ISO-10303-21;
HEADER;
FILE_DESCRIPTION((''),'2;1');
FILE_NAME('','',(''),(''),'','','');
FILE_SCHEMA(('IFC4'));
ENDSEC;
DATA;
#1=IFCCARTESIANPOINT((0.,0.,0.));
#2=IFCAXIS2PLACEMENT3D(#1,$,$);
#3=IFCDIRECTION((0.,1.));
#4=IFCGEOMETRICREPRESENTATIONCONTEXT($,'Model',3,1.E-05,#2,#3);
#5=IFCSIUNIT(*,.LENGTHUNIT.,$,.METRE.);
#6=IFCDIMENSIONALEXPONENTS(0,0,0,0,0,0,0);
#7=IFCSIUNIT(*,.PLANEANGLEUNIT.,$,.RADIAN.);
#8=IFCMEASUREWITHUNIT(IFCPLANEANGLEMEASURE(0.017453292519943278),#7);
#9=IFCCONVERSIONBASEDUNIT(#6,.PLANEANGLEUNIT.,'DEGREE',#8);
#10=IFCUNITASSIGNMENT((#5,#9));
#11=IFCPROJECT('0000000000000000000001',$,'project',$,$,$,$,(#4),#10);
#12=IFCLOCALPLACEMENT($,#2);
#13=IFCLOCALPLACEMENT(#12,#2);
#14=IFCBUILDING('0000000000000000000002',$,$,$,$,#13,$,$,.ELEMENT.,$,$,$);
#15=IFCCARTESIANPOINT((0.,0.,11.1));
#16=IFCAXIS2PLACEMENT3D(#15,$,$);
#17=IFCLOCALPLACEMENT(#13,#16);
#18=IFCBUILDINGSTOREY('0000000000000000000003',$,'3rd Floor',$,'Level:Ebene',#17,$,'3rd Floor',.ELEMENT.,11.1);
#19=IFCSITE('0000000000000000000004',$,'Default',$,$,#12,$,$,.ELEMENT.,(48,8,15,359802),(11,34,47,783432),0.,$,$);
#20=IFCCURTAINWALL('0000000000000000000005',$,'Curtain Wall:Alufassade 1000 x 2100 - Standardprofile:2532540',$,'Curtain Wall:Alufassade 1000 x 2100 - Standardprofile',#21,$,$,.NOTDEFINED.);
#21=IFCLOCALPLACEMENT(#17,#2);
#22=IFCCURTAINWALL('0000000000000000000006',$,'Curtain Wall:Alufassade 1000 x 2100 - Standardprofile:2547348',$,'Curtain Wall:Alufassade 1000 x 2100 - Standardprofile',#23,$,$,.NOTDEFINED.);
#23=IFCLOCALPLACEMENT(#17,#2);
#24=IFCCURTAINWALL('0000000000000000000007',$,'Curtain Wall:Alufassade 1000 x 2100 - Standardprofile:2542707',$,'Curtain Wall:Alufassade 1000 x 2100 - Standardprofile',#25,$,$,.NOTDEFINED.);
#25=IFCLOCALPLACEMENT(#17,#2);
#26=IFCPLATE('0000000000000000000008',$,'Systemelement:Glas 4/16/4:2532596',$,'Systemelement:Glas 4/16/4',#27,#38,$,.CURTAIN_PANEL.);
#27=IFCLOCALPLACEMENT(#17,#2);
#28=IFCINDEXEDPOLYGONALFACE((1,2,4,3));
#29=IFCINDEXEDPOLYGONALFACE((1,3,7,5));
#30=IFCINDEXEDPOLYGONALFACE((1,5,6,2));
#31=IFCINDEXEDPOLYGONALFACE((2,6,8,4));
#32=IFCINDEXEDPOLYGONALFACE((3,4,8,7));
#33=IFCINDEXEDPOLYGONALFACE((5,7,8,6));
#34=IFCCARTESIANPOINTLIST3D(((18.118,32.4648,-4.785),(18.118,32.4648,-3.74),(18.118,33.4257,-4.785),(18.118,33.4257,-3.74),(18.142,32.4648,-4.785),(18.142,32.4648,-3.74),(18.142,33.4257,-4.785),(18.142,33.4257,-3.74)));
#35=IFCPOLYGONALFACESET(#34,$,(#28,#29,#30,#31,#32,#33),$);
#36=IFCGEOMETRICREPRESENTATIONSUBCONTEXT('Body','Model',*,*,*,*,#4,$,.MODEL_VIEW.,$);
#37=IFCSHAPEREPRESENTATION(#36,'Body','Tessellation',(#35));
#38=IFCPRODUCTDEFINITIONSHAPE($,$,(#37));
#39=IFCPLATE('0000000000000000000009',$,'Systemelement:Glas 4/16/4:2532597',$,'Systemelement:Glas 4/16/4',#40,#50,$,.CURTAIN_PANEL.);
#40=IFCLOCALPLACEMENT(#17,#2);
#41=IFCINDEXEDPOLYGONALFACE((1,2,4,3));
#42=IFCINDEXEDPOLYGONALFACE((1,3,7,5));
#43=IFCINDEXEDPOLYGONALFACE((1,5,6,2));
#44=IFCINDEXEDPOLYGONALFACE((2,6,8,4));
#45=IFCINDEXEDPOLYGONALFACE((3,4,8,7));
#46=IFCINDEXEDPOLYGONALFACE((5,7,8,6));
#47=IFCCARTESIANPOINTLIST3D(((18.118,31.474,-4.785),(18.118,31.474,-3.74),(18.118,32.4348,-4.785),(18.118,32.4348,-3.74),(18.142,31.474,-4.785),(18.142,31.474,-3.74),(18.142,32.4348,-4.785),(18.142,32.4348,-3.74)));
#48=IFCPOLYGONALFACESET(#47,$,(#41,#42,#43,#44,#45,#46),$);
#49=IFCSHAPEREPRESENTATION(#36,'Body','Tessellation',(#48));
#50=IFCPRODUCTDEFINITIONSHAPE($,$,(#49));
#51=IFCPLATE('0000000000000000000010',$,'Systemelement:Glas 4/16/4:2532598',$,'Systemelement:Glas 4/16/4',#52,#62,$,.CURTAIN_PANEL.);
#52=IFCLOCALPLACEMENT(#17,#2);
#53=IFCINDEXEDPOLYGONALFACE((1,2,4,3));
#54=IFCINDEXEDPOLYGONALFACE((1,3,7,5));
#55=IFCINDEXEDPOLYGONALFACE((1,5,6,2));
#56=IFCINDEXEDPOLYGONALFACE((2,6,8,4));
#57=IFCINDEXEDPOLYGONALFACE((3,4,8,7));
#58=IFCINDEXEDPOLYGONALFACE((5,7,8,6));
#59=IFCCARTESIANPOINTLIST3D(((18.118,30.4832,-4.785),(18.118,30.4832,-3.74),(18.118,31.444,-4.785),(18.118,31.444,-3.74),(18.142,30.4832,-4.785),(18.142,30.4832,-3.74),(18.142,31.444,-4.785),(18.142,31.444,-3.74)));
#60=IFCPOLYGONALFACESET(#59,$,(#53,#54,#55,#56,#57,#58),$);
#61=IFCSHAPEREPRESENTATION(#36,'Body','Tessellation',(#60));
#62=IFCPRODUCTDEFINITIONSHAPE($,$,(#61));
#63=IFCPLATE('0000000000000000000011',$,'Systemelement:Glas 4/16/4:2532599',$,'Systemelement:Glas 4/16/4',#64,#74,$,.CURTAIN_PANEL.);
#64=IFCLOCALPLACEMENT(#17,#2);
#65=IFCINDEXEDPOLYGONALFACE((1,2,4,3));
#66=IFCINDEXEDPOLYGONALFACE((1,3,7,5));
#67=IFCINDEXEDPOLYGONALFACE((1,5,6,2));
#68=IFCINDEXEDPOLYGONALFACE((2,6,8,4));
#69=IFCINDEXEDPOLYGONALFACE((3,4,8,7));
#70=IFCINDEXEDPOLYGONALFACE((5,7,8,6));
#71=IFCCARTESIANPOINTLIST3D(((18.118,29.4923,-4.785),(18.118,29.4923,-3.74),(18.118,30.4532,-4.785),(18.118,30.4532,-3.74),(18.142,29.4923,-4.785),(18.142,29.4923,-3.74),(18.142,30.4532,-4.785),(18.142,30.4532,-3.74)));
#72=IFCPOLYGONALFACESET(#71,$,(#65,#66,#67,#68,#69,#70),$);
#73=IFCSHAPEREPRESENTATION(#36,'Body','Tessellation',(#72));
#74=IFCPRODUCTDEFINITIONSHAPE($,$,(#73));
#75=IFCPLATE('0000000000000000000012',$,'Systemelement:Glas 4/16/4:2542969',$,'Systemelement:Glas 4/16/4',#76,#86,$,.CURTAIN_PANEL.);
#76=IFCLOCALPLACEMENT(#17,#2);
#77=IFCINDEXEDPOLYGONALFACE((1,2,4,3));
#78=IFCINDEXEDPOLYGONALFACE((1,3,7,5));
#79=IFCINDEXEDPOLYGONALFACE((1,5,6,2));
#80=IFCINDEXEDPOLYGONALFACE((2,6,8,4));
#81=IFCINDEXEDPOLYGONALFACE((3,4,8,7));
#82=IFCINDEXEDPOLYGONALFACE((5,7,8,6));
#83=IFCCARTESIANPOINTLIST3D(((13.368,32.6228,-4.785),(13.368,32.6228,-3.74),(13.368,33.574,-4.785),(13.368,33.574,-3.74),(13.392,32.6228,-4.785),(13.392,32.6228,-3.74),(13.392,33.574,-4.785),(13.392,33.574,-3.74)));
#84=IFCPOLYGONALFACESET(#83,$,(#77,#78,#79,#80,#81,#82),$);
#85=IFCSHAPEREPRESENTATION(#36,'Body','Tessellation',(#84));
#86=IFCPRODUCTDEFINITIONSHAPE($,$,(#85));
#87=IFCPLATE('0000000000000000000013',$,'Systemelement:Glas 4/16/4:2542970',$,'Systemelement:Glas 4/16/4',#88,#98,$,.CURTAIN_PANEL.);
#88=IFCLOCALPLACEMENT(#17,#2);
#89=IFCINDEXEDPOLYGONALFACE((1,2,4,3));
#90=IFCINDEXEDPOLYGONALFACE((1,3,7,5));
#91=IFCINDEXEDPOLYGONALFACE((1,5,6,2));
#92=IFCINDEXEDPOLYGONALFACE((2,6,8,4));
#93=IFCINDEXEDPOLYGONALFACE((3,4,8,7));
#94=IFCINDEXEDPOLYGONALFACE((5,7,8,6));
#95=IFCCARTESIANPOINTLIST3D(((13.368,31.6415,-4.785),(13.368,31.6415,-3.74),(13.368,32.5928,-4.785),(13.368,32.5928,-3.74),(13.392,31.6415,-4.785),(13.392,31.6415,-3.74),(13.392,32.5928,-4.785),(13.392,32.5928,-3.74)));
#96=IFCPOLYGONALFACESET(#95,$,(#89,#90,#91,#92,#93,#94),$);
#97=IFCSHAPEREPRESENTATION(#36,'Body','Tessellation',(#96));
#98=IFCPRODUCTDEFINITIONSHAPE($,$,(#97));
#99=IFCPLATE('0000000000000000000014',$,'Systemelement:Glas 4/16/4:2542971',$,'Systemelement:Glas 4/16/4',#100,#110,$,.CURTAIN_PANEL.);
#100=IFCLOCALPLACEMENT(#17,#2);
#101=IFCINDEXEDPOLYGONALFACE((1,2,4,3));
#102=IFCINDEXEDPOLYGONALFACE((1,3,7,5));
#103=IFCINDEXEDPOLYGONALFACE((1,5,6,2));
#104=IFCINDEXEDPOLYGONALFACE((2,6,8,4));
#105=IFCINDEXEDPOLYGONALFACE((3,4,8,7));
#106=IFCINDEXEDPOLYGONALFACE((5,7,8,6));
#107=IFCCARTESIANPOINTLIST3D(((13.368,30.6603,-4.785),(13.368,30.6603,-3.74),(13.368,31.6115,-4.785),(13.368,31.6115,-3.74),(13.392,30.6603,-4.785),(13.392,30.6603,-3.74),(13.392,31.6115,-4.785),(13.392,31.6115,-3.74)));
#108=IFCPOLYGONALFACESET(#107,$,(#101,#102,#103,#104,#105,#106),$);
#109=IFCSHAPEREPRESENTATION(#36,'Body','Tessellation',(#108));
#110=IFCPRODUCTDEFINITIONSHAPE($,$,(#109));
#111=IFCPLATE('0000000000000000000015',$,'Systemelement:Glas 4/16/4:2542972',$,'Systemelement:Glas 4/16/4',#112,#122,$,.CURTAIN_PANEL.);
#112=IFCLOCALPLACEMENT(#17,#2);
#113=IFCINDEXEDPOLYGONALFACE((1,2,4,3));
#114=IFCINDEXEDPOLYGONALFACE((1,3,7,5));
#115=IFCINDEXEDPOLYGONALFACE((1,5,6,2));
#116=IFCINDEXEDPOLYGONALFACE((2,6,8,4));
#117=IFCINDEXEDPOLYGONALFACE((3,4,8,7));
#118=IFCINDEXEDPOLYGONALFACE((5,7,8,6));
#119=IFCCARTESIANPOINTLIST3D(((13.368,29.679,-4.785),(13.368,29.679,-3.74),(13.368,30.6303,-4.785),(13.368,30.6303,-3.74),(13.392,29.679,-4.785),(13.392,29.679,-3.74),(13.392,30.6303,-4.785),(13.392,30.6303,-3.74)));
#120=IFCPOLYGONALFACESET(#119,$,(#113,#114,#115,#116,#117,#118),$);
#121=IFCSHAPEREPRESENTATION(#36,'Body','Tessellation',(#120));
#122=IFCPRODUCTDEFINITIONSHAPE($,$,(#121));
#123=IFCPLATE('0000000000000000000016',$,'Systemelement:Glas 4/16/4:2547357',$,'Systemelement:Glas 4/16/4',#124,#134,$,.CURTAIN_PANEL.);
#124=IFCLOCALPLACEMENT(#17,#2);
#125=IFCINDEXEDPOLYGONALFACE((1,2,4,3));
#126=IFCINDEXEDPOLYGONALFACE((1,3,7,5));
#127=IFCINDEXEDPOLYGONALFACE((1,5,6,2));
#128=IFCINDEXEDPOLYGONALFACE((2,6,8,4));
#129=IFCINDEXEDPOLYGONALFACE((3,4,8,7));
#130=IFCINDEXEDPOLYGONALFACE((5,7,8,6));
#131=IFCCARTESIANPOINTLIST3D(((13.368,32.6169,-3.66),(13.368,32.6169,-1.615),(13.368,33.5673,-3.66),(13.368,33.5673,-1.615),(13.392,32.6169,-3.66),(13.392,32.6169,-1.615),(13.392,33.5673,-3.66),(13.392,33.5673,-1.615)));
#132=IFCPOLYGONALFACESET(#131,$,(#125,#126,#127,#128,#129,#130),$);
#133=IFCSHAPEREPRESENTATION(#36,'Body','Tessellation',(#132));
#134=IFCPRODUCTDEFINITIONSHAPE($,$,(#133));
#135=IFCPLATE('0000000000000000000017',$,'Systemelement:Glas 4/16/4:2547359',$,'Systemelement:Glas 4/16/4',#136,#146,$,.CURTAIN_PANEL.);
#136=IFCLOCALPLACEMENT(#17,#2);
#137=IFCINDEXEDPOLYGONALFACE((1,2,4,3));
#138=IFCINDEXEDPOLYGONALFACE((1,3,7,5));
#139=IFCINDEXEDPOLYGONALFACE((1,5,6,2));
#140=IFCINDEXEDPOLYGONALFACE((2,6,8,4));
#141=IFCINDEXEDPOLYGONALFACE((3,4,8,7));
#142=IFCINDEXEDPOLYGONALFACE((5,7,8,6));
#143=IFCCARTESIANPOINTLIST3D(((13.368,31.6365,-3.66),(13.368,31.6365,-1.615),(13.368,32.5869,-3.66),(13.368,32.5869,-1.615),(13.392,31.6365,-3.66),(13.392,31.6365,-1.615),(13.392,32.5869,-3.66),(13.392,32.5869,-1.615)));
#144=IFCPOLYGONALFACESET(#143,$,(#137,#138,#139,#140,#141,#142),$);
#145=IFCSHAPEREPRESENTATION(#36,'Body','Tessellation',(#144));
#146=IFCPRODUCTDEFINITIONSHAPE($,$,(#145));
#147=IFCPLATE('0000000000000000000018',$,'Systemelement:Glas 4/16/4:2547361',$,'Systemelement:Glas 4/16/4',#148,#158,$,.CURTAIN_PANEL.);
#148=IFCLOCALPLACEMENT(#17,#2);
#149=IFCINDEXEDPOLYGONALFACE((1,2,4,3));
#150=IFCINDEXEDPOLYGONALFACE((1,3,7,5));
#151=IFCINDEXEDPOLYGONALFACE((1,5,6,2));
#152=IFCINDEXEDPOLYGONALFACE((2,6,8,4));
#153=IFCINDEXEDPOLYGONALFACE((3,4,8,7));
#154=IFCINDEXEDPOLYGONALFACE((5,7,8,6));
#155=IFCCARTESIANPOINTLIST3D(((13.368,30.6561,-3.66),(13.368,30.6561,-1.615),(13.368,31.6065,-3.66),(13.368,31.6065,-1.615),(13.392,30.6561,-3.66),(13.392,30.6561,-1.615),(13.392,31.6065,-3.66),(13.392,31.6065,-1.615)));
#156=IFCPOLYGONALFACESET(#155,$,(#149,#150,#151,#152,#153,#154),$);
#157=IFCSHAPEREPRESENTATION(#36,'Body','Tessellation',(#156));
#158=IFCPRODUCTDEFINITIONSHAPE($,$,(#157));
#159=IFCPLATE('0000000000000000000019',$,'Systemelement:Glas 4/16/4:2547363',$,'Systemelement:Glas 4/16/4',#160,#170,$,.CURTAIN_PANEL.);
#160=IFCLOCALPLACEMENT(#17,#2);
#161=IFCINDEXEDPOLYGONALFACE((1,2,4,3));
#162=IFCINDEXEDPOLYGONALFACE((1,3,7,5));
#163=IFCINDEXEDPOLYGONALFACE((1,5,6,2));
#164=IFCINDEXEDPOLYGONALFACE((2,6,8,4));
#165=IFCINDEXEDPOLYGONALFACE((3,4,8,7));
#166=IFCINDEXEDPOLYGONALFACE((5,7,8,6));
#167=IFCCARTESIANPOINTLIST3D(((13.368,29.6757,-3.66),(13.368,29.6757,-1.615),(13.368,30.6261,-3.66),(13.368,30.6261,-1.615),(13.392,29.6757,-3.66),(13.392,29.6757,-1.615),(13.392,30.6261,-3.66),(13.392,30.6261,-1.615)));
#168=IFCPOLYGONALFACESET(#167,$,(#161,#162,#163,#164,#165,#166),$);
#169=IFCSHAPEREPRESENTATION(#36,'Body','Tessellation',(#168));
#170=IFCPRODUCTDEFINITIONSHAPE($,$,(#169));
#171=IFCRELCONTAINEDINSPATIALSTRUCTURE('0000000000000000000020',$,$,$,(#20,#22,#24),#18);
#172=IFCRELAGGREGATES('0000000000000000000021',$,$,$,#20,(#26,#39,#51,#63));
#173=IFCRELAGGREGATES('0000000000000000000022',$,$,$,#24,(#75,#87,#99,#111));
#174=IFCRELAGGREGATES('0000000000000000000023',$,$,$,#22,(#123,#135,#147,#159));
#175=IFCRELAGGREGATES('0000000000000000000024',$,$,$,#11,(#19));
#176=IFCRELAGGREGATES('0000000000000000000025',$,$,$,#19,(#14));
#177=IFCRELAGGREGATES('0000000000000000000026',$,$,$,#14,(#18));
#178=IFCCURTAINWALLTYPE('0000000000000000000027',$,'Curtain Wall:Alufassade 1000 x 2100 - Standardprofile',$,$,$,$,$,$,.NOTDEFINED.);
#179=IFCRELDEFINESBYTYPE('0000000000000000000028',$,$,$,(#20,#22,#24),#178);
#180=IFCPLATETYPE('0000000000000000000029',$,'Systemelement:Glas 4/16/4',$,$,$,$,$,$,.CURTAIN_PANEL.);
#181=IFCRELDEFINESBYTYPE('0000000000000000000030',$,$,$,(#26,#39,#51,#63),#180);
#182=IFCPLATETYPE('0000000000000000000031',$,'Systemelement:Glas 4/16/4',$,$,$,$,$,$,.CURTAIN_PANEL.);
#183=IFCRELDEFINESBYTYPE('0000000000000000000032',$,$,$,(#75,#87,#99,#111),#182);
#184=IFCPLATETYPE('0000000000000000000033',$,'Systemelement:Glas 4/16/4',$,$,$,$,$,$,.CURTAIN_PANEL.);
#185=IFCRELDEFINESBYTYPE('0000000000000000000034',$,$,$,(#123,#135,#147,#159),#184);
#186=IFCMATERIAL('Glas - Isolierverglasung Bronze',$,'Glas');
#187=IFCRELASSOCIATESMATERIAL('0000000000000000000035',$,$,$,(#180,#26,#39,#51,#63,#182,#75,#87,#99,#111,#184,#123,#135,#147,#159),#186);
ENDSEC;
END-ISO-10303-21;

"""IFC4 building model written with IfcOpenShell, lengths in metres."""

from ifc_helpers import new_model, entity, si_unit, converted_unit, direction, frame, origin, place, context, subcontext, project, spatial, indexed_curve, outline, extrude, source, transform, mapped, material, type_object, type_shapes, element, aggregate, save


model = new_model("IFC4")

# Units and contexts
model_context = context("Model", 3, precision=1e-05, world=origin(), true_north=direction((0.0, 1.0)))
body_context = subcontext(model_context, "Body", "Model", "MODEL_VIEW")
ifc_project = project(units=[si_unit("LENGTHUNIT", "METRE"), converted_unit("PLANEANGLEUNIT", "DEGREE", entity("IfcPlaneAngleMeasure", 0.017453292519943278), si_unit("PLANEANGLEUNIT", "RADIAN"), dimensions=[0, 0, 0, 0, 0, 0, 0])], contexts=[model_context])

# Site, building, storey
site_placement = place(None, origin())
site = spatial("IfcSite", under=ifc_project, at=site_placement, Name="Default", CompositionType="ELEMENT", RefLatitude=(48, 8, 15, 359802), RefLongitude=(11, 34, 47, 783432), RefElevation=0.0)
building_placement = place(site_placement, origin())
building = spatial("IfcBuilding", under=site, at=building_placement, CompositionType="ELEMENT")
storey_placement = place(building_placement, frame((0.0, 0.0, 11.1)))
storey = spatial("IfcBuildingStorey", under=building, at=storey_placement, Name="3rd Floor", ObjectType="Level:Ebene", LongName="3rd Floor", CompositionType="ELEMENT", Elevation=11.1)

# Curtain walls
curtain_wall_type = type_object("IfcCurtainWallType", Name="Curtain Wall:Alufassade 1000 x 2100 - Standardprofile", PredefinedType="NOTDEFINED")
curtain_wall_1_placement = place(storey_placement, frame((0.0, 0.0, -11.1)))
curtain_wall_1 = element("IfcCurtainWall", 1, at=curtain_wall_1_placement, inside=storey, type_object=curtain_wall_type, Name="Curtain Wall:Alufassade 1000 x 2100 - Standardprofile:2532540", ObjectType="Curtain Wall:Alufassade 1000 x 2100 - Standardprofile", PredefinedType="NOTDEFINED")
curtain_wall_2_placement = place(storey_placement, frame((0.0, 0.0, -11.1)))
curtain_wall_2 = element("IfcCurtainWall", 2, at=curtain_wall_2_placement, inside=storey, type_object=curtain_wall_type, Name="Curtain Wall:Alufassade 1000 x 2100 - Standardprofile:2547348", ObjectType="Curtain Wall:Alufassade 1000 x 2100 - Standardprofile", PredefinedType="NOTDEFINED")

# Curtain wall
curtain_wall_3_placement = place(storey_placement, frame((0.0, 0.0, -11.1)))
curtain_wall_3 = element("IfcCurtainWall", 3, at=curtain_wall_3_placement, inside=storey, type_object=curtain_wall_type, Name="Curtain Wall:Alufassade 1000 x 2100 - Standardprofile:2542707", ObjectType="Curtain Wall:Alufassade 1000 x 2100 - Standardprofile", PredefinedType="NOTDEFINED")

# Plates
ifc_material_1 = material(Name="Glas - Isolierverglasung Bronze", Category="Glas")
plate_type_1 = type_object("IfcPlateType", Name="Systemelement:Glas 4/16/4", PredefinedType="CURTAIN_PANEL", material=ifc_material_1)
shared_shape_1 = source(origin(), body_context, "Body", "SweptSolid", [
    extrude(outline(indexed_curve([(-0.012, -0.4804), (0.012, -0.4804), (0.012, 0.4804), (-0.012, 0.4804), (-0.012, -0.4804)], self_intersect=False)), frame((0.0, 0.0, 0.0), z_axis=(0.0, 0.0, 1.0), x_axis=(0.0, 1.0, 0.0)), (0.0, 0.0, 1.0), 1.045),
])
type_shapes(plate_type_1, [shared_shape_1])
plate_1_placement = place(curtain_wall_1_placement, frame((18.13, 32.9453, 6.315), z_axis=(0.0, 0.0, 1.0), x_axis=(0.0, -1.0, 0.0)))
plate_1 = element("IfcPlate", 4, at=plate_1_placement, type_object=plate_type_1, material=ifc_material_1, Name="Systemelement:Glas 4/16/4:2532596", ObjectType="Systemelement:Glas 4/16/4", PredefinedType="CURTAIN_PANEL", context=body_context, shape_type="MappedRepresentation", body=[
    mapped(shared_shape_1, transform((0.0, 0.0, 0.0), scale=1.0)),
])
plate_2_placement = place(curtain_wall_1_placement, frame((18.13, 31.9544, 6.315), z_axis=(0.0, 0.0, 1.0), x_axis=(0.0, -1.0, 0.0)))
plate_2 = element("IfcPlate", 5, at=plate_2_placement, type_object=plate_type_1, material=ifc_material_1, Name="Systemelement:Glas 4/16/4:2532597", ObjectType="Systemelement:Glas 4/16/4", PredefinedType="CURTAIN_PANEL", context=body_context, shape_type="MappedRepresentation", body=[
    mapped(shared_shape_1, transform((0.0, 0.0, 0.0), scale=1.0)),
])
plate_3_placement = place(curtain_wall_1_placement, frame((18.13, 30.9636, 6.315), z_axis=(0.0, 0.0, 1.0), x_axis=(0.0, -1.0, 0.0)))
plate_3 = element("IfcPlate", 6, at=plate_3_placement, type_object=plate_type_1, material=ifc_material_1, Name="Systemelement:Glas 4/16/4:2532598", ObjectType="Systemelement:Glas 4/16/4", PredefinedType="CURTAIN_PANEL", context=body_context, shape_type="MappedRepresentation", body=[
    mapped(shared_shape_1, transform((0.0, 0.0, 0.0), scale=1.0)),
])
plate_4_placement = place(curtain_wall_1_placement, frame((18.13, 29.9728, 6.315), z_axis=(0.0, 0.0, 1.0), x_axis=(0.0, -1.0, 0.0)))
plate_4 = element("IfcPlate", 7, at=plate_4_placement, type_object=plate_type_1, material=ifc_material_1, Name="Systemelement:Glas 4/16/4:2532599", ObjectType="Systemelement:Glas 4/16/4", PredefinedType="CURTAIN_PANEL", context=body_context, shape_type="MappedRepresentation", body=[
    mapped(shared_shape_1, transform((0.0, 0.0, 0.0), scale=1.0)),
])
aggregate(curtain_wall_1, [plate_1, plate_2, plate_3, plate_4])
plate_type_2 = type_object("IfcPlateType", Name="Systemelement:Glas 4/16/4", PredefinedType="CURTAIN_PANEL", material=ifc_material_1)
shared_shape_2 = source(origin(), body_context, "Body", "SweptSolid", [
    extrude(outline(indexed_curve([(-0.012, -0.4756), (0.012, -0.4756), (0.012, 0.4756), (-0.012, 0.4756), (-0.012, -0.4756)], self_intersect=False)), frame((0.0, 0.0, 0.0), z_axis=(0.0, 0.0, 1.0), x_axis=(0.0, 1.0, 0.0)), (0.0, 0.0, 1.0), 1.045),
])
type_shapes(plate_type_2, [shared_shape_2])
plate_5_placement = place(curtain_wall_3_placement, frame((13.38, 33.0984, 6.315), z_axis=(0.0, 0.0, 1.0), x_axis=(0.0, -1.0, 0.0)))
plate_5 = element("IfcPlate", 8, at=plate_5_placement, type_object=plate_type_2, material=ifc_material_1, Name="Systemelement:Glas 4/16/4:2542969", ObjectType="Systemelement:Glas 4/16/4", PredefinedType="CURTAIN_PANEL", context=body_context, shape_type="MappedRepresentation", body=[
    mapped(shared_shape_2, transform((0.0, 0.0, 0.0), scale=1.0)),
])
plate_6_placement = place(curtain_wall_3_placement, frame((13.38, 32.1171, 6.315), z_axis=(0.0, 0.0, 1.0), x_axis=(0.0, -1.0, 0.0)))
plate_6 = element("IfcPlate", 9, at=plate_6_placement, type_object=plate_type_2, material=ifc_material_1, Name="Systemelement:Glas 4/16/4:2542970", ObjectType="Systemelement:Glas 4/16/4", PredefinedType="CURTAIN_PANEL", context=body_context, shape_type="MappedRepresentation", body=[
    mapped(shared_shape_2, transform((0.0, 0.0, 0.0), scale=1.0)),
])
plate_7_placement = place(curtain_wall_3_placement, frame((13.38, 31.1359, 6.315), z_axis=(0.0, 0.0, 1.0), x_axis=(0.0, -1.0, 0.0)))
plate_7 = element("IfcPlate", 10, at=plate_7_placement, type_object=plate_type_2, material=ifc_material_1, Name="Systemelement:Glas 4/16/4:2542971", ObjectType="Systemelement:Glas 4/16/4", PredefinedType="CURTAIN_PANEL", context=body_context, shape_type="MappedRepresentation", body=[
    mapped(shared_shape_2, transform((0.0, 0.0, 0.0), scale=1.0)),
])
plate_8_placement = place(curtain_wall_3_placement, frame((13.38, 30.1546, 6.315), z_axis=(0.0, 0.0, 1.0), x_axis=(0.0, -1.0, 0.0)))
plate_8 = element("IfcPlate", 11, at=plate_8_placement, type_object=plate_type_2, material=ifc_material_1, Name="Systemelement:Glas 4/16/4:2542972", ObjectType="Systemelement:Glas 4/16/4", PredefinedType="CURTAIN_PANEL", context=body_context, shape_type="MappedRepresentation", body=[
    mapped(shared_shape_2, transform((0.0, 0.0, 0.0), scale=1.0)),
])
aggregate(curtain_wall_3, [plate_5, plate_6, plate_7, plate_8])
plate_type_3 = type_object("IfcPlateType", Name="Systemelement:Glas 4/16/4", PredefinedType="CURTAIN_PANEL", material=ifc_material_1)
shared_shape_3 = source(origin(), body_context, "Body", "SweptSolid", [
    extrude(outline(indexed_curve([(-0.012, -0.4752), (0.012, -0.4752), (0.012, 0.4752), (-0.012, 0.4752), (-0.012, -0.4752)], self_intersect=False)), frame((0.0, 0.0, 0.0), z_axis=(0.0, 0.0, 1.0), x_axis=(0.0, 1.0, 0.0)), (0.0, 0.0, 1.0), 2.045),
])
type_shapes(plate_type_3, [shared_shape_3])
plate_9_placement = place(curtain_wall_2_placement, frame((13.38, 33.0921, 7.44), z_axis=(0.0, 0.0, 1.0), x_axis=(0.0, -1.0, 0.0)))
plate_9 = element("IfcPlate", 12, at=plate_9_placement, type_object=plate_type_3, material=ifc_material_1, Name="Systemelement:Glas 4/16/4:2547357", ObjectType="Systemelement:Glas 4/16/4", PredefinedType="CURTAIN_PANEL", context=body_context, shape_type="MappedRepresentation", body=[
    mapped(shared_shape_3, transform((0.0, 0.0, 0.0), scale=1.0)),
])
plate_10_placement = place(curtain_wall_2_placement, frame((13.38, 32.1117, 7.44), z_axis=(0.0, 0.0, 1.0), x_axis=(0.0, -1.0, 0.0)))
plate_10 = element("IfcPlate", 13, at=plate_10_placement, type_object=plate_type_3, material=ifc_material_1, Name="Systemelement:Glas 4/16/4:2547359", ObjectType="Systemelement:Glas 4/16/4", PredefinedType="CURTAIN_PANEL", context=body_context, shape_type="MappedRepresentation", body=[
    mapped(shared_shape_3, transform((0.0, 0.0, 0.0), scale=1.0)),
])
plate_11_placement = place(curtain_wall_2_placement, frame((13.38, 31.1313, 7.44), z_axis=(0.0, 0.0, 1.0), x_axis=(0.0, -1.0, 0.0)))
plate_11 = element("IfcPlate", 14, at=plate_11_placement, type_object=plate_type_3, material=ifc_material_1, Name="Systemelement:Glas 4/16/4:2547361", ObjectType="Systemelement:Glas 4/16/4", PredefinedType="CURTAIN_PANEL", context=body_context, shape_type="MappedRepresentation", body=[
    mapped(shared_shape_3, transform((0.0, 0.0, 0.0), scale=1.0)),
])
plate_12_placement = place(curtain_wall_2_placement, frame((13.38, 30.1509, 7.44), z_axis=(0.0, 0.0, 1.0), x_axis=(0.0, -1.0, 0.0)))
plate_12 = element("IfcPlate", 15, at=plate_12_placement, type_object=plate_type_3, material=ifc_material_1, Name="Systemelement:Glas 4/16/4:2547363", ObjectType="Systemelement:Glas 4/16/4", PredefinedType="CURTAIN_PANEL", context=body_context, shape_type="MappedRepresentation", body=[
    mapped(shared_shape_3, transform((0.0, 0.0, 0.0), scale=1.0)),
])
aggregate(curtain_wall_2, [plate_9, plate_10, plate_11, plate_12])

save(model, "model.ifc")
